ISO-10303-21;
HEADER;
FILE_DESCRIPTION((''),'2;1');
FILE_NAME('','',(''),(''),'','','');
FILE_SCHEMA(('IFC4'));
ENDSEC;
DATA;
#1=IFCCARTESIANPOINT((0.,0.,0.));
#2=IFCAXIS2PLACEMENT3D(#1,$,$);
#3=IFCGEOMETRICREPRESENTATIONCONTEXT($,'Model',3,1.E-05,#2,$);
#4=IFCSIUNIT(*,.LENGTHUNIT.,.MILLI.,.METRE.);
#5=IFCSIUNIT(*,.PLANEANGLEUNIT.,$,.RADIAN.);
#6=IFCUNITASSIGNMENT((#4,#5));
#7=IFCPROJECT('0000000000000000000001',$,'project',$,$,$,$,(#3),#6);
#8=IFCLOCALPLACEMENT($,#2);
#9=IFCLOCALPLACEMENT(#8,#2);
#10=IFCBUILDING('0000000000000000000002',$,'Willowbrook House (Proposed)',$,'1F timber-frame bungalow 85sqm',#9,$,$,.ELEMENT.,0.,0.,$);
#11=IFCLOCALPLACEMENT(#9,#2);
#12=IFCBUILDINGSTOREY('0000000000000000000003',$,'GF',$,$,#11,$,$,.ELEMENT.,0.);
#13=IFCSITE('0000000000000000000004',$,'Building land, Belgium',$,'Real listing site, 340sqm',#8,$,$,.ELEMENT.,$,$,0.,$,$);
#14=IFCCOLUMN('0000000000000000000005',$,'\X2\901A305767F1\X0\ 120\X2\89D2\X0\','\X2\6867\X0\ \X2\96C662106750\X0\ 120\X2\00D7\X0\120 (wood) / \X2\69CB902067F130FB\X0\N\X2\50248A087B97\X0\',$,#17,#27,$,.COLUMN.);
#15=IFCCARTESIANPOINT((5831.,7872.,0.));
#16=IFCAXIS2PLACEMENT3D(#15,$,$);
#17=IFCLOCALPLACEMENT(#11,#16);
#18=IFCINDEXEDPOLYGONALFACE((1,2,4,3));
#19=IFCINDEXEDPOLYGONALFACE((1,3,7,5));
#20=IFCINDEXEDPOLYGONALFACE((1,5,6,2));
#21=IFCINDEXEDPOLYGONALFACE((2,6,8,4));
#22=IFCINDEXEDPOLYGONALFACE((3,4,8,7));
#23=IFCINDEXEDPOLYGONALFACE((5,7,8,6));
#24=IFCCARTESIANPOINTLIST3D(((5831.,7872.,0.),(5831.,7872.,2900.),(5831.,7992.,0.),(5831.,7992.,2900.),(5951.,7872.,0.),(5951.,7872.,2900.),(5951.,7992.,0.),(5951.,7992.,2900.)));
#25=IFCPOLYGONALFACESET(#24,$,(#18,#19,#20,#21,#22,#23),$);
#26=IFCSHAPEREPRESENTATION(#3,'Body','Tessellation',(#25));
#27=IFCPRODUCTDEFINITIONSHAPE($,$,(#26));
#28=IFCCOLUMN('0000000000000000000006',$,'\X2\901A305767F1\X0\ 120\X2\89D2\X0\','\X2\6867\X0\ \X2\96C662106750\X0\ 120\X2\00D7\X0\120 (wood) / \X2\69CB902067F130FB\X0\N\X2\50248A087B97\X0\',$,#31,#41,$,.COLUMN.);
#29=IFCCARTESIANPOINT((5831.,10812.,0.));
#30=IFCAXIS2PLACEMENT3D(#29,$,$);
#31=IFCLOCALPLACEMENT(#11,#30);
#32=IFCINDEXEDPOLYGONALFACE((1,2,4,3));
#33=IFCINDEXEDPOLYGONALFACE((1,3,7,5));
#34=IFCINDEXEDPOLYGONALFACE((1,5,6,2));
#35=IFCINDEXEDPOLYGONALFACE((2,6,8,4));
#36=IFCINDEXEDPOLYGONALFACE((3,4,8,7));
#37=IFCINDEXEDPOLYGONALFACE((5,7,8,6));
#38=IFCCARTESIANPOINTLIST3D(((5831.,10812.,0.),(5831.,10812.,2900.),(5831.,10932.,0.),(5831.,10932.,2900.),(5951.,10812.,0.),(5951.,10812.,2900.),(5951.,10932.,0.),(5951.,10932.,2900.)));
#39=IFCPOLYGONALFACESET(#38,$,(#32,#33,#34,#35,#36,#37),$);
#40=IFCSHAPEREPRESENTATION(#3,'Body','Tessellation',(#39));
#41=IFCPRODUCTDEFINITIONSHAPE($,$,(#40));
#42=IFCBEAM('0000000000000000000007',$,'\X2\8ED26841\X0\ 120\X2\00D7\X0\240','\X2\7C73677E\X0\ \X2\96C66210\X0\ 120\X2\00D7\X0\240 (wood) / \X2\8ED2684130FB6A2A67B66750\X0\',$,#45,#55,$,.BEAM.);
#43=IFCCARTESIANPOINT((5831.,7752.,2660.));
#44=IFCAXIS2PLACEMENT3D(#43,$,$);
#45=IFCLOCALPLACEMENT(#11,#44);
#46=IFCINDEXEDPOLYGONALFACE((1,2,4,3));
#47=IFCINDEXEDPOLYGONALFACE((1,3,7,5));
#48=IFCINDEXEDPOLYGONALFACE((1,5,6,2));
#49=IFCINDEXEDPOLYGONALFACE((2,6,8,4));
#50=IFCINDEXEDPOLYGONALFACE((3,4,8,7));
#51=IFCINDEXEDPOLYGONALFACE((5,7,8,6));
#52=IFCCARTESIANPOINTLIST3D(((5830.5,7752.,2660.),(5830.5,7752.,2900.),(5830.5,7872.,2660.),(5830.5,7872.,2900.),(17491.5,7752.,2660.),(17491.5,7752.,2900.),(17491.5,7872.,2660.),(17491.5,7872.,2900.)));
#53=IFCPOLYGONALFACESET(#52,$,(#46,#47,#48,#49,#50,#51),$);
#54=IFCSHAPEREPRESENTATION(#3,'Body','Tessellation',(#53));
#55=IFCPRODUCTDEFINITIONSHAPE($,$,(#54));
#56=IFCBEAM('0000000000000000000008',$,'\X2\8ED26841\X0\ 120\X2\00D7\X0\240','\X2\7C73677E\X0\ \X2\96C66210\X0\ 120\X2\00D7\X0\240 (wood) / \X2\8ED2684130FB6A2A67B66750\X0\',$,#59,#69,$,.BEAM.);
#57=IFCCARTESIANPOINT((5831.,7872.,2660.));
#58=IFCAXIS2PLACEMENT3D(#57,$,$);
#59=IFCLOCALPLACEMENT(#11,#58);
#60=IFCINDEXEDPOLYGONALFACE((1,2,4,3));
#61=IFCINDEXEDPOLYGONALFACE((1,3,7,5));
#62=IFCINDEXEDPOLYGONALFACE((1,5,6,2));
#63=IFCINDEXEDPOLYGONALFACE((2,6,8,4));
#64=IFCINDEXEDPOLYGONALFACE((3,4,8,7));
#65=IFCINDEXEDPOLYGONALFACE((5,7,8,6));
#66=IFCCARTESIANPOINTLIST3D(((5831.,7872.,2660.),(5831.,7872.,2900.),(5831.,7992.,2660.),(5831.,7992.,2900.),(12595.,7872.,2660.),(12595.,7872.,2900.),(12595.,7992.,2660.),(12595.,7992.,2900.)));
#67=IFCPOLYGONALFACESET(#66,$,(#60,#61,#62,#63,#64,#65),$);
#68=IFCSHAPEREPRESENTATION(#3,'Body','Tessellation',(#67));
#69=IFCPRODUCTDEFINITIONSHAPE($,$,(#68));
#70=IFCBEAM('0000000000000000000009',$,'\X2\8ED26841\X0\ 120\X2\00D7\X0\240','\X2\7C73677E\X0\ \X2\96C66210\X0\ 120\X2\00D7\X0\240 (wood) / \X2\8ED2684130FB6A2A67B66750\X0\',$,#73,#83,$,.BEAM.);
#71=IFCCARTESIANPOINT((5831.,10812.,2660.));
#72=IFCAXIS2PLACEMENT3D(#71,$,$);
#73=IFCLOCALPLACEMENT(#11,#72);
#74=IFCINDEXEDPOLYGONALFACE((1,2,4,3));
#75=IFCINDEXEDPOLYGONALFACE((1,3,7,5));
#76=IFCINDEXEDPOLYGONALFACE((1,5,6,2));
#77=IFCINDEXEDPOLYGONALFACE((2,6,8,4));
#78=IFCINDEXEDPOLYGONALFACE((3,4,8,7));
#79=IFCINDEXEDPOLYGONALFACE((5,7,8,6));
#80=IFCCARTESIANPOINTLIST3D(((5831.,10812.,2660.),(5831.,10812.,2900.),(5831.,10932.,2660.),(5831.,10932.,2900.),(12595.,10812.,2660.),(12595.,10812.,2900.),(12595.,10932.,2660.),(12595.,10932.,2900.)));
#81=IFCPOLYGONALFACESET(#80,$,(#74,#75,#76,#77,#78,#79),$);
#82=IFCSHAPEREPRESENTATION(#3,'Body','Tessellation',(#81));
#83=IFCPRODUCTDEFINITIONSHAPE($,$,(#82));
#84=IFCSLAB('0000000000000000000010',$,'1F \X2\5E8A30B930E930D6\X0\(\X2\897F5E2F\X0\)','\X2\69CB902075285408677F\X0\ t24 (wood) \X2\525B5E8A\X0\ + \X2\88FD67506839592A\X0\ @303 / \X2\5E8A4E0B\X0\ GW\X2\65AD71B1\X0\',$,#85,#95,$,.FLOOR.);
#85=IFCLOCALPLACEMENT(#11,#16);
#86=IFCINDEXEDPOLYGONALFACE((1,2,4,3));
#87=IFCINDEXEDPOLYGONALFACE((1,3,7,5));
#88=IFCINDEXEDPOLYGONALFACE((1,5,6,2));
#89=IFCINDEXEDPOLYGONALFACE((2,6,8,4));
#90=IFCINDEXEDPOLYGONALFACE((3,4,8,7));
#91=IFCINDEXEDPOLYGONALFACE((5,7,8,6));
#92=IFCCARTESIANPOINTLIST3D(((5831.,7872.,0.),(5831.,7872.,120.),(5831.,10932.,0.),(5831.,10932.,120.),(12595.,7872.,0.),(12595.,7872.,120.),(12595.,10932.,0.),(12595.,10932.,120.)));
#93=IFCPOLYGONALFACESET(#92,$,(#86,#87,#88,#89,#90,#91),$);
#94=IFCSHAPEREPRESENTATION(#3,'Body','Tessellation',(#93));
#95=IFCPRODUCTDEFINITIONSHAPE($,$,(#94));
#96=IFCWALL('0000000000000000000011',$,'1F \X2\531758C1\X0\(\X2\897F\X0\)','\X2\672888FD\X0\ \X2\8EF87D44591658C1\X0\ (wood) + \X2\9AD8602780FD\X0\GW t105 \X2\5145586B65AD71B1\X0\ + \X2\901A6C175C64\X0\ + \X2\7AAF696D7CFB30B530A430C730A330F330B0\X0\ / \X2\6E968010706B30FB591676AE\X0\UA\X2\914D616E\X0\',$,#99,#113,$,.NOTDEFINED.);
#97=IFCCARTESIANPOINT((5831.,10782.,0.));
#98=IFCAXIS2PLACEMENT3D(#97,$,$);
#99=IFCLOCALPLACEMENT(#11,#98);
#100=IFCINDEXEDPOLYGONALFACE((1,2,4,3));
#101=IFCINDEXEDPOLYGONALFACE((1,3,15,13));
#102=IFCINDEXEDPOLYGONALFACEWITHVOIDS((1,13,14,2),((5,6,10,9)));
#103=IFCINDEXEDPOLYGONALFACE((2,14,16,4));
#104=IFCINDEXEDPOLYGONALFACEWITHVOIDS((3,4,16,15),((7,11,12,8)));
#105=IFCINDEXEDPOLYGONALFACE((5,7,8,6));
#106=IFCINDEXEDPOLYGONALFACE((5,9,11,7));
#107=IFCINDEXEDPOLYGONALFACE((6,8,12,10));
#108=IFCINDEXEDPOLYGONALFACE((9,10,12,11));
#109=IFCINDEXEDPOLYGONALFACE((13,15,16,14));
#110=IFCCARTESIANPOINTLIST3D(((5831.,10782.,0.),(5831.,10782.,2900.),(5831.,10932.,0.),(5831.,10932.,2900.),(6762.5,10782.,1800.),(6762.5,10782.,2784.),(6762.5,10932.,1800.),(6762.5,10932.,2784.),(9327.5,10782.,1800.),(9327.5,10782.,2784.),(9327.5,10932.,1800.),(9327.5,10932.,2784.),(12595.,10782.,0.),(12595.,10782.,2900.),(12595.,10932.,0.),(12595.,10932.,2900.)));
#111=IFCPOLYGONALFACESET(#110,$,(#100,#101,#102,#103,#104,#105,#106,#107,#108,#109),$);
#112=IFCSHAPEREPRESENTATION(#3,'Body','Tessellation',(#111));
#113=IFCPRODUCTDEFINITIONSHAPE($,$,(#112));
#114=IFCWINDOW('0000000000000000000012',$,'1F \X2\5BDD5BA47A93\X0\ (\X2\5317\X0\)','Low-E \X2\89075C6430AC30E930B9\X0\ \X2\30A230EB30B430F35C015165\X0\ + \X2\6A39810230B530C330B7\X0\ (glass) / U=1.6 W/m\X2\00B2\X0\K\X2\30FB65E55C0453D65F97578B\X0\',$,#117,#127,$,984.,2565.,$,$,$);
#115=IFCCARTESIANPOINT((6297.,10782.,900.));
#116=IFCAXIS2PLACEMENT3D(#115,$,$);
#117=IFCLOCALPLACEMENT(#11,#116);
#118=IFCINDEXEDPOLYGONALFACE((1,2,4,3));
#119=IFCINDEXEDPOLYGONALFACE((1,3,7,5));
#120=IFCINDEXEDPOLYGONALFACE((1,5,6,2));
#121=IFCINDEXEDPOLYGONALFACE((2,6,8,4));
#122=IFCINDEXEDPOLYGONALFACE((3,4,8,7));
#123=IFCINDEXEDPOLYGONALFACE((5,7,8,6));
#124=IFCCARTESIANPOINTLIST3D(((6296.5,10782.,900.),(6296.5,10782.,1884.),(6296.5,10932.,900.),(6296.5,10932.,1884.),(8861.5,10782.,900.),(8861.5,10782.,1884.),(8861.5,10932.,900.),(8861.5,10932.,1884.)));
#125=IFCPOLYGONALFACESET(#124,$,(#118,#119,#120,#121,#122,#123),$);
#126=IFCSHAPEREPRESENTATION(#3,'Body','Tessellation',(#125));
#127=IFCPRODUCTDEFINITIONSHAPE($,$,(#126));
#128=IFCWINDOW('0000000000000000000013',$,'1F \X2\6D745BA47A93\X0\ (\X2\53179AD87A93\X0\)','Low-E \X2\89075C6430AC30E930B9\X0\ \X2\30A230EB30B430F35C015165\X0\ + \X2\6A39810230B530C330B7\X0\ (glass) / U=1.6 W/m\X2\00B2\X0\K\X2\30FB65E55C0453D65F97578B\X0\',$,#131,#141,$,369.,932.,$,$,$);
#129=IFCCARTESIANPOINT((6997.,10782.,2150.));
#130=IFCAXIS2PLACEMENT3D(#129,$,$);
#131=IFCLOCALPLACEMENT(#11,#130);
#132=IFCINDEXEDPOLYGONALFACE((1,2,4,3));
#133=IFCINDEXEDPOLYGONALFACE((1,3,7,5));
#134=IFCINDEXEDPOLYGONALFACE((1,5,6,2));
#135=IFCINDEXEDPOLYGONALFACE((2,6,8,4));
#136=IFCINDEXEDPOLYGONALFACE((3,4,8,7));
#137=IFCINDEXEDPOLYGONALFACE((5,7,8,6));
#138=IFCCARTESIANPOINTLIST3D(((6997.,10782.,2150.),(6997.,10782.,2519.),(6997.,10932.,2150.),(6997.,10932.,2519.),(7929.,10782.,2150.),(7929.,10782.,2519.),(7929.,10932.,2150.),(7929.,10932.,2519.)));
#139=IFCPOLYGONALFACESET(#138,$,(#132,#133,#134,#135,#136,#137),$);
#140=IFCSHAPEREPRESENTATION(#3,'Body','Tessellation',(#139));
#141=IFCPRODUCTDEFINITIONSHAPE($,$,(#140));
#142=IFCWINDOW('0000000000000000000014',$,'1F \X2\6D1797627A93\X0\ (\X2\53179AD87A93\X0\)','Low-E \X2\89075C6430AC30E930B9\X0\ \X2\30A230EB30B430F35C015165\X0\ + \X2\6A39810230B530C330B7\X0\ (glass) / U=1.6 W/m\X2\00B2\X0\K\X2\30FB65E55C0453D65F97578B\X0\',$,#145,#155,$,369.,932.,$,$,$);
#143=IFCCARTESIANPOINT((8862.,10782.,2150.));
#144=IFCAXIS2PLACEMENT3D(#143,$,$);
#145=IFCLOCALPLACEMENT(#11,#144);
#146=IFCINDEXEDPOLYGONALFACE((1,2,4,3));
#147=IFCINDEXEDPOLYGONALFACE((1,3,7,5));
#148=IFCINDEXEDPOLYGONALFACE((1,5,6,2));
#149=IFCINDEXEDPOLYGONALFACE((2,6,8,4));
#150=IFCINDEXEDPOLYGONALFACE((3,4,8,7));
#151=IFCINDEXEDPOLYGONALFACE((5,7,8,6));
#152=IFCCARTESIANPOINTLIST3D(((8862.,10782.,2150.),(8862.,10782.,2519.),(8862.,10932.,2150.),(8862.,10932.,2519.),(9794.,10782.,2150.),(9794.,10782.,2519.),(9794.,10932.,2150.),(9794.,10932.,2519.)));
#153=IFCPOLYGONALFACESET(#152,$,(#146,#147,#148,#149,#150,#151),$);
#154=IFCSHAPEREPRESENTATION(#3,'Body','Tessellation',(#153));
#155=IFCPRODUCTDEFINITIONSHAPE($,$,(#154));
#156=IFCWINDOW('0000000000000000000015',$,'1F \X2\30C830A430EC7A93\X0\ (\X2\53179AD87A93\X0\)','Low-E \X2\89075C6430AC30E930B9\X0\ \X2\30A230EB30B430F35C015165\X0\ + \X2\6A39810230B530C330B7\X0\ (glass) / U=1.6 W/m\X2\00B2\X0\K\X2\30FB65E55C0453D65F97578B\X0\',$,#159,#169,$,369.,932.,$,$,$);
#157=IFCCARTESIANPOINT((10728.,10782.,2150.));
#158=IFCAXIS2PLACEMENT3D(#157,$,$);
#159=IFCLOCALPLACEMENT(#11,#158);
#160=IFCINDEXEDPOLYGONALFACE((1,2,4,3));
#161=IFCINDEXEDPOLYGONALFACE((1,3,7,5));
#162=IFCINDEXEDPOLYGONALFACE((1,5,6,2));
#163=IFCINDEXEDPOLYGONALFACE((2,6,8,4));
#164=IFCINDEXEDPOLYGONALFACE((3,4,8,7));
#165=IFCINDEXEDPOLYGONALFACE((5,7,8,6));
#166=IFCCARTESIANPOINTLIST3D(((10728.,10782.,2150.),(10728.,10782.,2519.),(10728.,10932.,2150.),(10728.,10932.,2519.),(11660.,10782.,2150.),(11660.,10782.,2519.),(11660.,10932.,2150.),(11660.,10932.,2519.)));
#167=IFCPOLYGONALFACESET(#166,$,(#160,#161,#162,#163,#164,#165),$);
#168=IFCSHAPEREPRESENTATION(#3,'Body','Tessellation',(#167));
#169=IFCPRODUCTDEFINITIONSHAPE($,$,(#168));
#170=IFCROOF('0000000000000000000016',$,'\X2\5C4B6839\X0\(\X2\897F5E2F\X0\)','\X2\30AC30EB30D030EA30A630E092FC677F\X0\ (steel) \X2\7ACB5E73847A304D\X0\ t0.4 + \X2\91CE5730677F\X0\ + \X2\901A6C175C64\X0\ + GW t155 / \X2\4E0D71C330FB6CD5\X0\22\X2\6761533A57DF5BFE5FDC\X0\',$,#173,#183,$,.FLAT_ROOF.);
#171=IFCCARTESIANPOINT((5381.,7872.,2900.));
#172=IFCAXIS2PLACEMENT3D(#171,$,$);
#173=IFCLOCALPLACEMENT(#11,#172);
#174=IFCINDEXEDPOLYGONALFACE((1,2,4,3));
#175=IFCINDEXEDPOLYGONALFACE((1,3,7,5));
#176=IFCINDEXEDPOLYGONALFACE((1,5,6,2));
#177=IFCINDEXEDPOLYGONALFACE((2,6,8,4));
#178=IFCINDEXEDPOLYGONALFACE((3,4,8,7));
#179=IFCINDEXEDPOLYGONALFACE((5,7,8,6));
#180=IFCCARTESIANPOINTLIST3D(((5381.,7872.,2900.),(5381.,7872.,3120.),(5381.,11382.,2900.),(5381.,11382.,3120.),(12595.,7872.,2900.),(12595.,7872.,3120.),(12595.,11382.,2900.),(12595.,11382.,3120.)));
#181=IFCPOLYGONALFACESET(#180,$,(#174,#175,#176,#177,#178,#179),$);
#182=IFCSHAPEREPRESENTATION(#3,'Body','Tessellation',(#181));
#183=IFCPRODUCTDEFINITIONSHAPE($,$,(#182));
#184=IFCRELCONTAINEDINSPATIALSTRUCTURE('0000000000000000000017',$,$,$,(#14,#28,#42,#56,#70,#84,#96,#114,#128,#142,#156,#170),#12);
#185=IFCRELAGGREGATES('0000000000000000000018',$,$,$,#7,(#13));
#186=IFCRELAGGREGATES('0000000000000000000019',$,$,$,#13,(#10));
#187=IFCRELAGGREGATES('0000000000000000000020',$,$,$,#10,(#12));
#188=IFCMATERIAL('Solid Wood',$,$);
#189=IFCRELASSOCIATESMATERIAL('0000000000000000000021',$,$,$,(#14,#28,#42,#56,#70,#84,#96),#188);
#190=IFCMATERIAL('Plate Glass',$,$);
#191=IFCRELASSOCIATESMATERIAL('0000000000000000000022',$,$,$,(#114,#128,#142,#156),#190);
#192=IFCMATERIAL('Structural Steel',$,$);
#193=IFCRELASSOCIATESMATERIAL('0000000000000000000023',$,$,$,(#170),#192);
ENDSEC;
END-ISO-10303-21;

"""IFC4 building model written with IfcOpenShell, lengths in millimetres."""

from ifc_helpers import new_model, si_unit, frame, frame_2d, origin, place, context, project, spatial, rectangle, extrude, material, element, fill, save


model = new_model("IFC4")

# Units and contexts
model_context = context("Model", 3, precision=1e-05, world=origin())
ifc_project = project(units=[si_unit("LENGTHUNIT", "METRE", prefix="MILLI"), si_unit("PLANEANGLEUNIT", "RADIAN")], contexts=[model_context])

# Site, building, storey
site_placement = place(None, origin())
site = spatial("IfcSite", under=ifc_project, at=site_placement, Name="Building land, Belgium", ObjectType="Real listing site, 340sqm", CompositionType="ELEMENT", RefElevation=0.0)
building_placement = place(site_placement, origin())
building = spatial("IfcBuilding", under=site, at=building_placement, Name="Willowbrook House (Proposed)", ObjectType="1F timber-frame bungalow 85sqm", CompositionType="ELEMENT", ElevationOfRefHeight=0.0, ElevationOfTerrain=0.0)
storey_placement = place(building_placement, origin())
storey = spatial("IfcBuildingStorey", under=building, at=storey_placement, Name="GF", CompositionType="ELEMENT", Elevation=0.0)

# Columns
ifc_material_1 = material(Name="Solid Wood")
column_1_placement = place(storey_placement, frame((5831.0, 7872.0, 0.0)))
element("IfcColumn", 1, at=column_1_placement, inside=storey, material=ifc_material_1, Name="通し柱 120角", Description="桧 集成材 120×120 (wood) / 構造柱・N値計算", PredefinedType="COLUMN", context=model_context, shape_type="SweptSolid", body=[
    extrude(rectangle(XDim=120.0, YDim=120.0, at=frame_2d((60.0, 60.0))), frame((5831.0, 7872.0, 0.0)), (0.0, 0.0, 1.0), 2900.0),
])
column_2_placement = place(storey_placement, frame((5831.0, 10812.0, 0.0)))
element("IfcColumn", 2, at=column_2_placement, inside=storey, material=ifc_material_1, Name="通し柱 120角", Description="桧 集成材 120×120 (wood) / 構造柱・N値計算", PredefinedType="COLUMN", context=model_context, shape_type="SweptSolid", body=[
    extrude(rectangle(XDim=120.0, YDim=120.0, at=frame_2d((60.0, 60.0))), frame((5831.0, 10812.0, 0.0)), (0.0, 0.0, 1.0), 2900.0),
])

# Beams
beam_1_placement = place(storey_placement, frame((5831.0, 7752.0, 2660.0)))
element("IfcBeam", 3, at=beam_1_placement, inside=storey, material=ifc_material_1, Name="軒桁 120×240", Description="米松 集成 120×240 (wood) / 軒桁・横架材", PredefinedType="BEAM", context=model_context, shape_type="SweptSolid", body=[
    extrude(rectangle(XDim=11661.0, YDim=120.0, at=frame_2d((5830.0, 60.0))), frame((5831.0, 7752.0, 2660.0)), (0.0, 0.0, 1.0), 240.0),
])
beam_2_placement = place(storey_placement, frame((5831.0, 7872.0, 2660.0)))
element("IfcBeam", 4, at=beam_2_placement, inside=storey, material=ifc_material_1, Name="軒桁 120×240", Description="米松 集成 120×240 (wood) / 軒桁・横架材", PredefinedType="BEAM", context=model_context, shape_type="SweptSolid", body=[
    extrude(rectangle(XDim=6764.0, YDim=120.0, at=frame_2d((3382.0, 60.0))), frame((5831.0, 7872.0, 2660.0)), (0.0, 0.0, 1.0), 240.0),
])
beam_3_placement = place(storey_placement, frame((5831.0, 10812.0, 2660.0)))
element("IfcBeam", 5, at=beam_3_placement, inside=storey, material=ifc_material_1, Name="軒桁 120×240", Description="米松 集成 120×240 (wood) / 軒桁・横架材", PredefinedType="BEAM", context=model_context, shape_type="SweptSolid", body=[
    extrude(rectangle(XDim=6764.0, YDim=120.0, at=frame_2d((3382.0, 60.0))), frame((5831.0, 10812.0, 2660.0)), (0.0, 0.0, 1.0), 240.0),
])

# Slab
slab_placement = place(storey_placement, frame((5831.0, 7872.0, 0.0)))
element("IfcSlab", 6, at=slab_placement, inside=storey, material=ifc_material_1, Name="1F 床スラブ(西帯)", Description="構造用合板 t24 (wood) 剛床 + 製材根太 @303 / 床下 GW断熱", PredefinedType="FLOOR", context=model_context, shape_type="SweptSolid", body=[
    extrude(rectangle(XDim=6764.0, YDim=3060.0, at=frame_2d((3382.0, 1530.0))), frame((5831.0, 7872.0, 0.0)), (0.0, 0.0, 1.0), 120.0),
])

# Wall, openings, windows
wall_1_placement = place(storey_placement, frame((5831.0, 10782.0, 0.0)))
wall_1 = element("IfcWall", 7, at=wall_1_placement, inside=storey, material=ifc_material_1, Name="1F 北壁(西)", Description="木製 軸組外壁 (wood) + 高性能GW t105 充填断熱 + 通気層 + 窯業系サイディング / 準耐火・外皮UA配慮", PredefinedType="NOTDEFINED", context=model_context, shape_type="SweptSolid", body=[
    extrude(rectangle(XDim=6764.0, YDim=150.0, at=frame_2d((3382.0, 75.0))), frame((5831.0, 10782.0, 0.0)), (0.0, 0.0, 1.0), 2900.0),
])
opening_1_placement = place(storey_placement, frame((6297.0, 10782.0, 900.0)))
opening_1 = element("IfcOpeningElement", 8, at=opening_1_placement, cuts=wall_1, PredefinedType="NOTDEFINED", context=model_context, shape_type="SweptSolid", body=[
    extrude(rectangle(XDim=2565.0, YDim=150.0, at=frame_2d((1282.0, 75.0))), frame((6297.0, 10782.0, 900.0)), (0.0, 0.0, 1.0), 984.0),
])
opening_2_placement = place(storey_placement, frame((6997.0, 10782.0, 2150.0)))
opening_2 = element("IfcOpeningElement", 9, at=opening_2_placement, cuts=wall_1, PredefinedType="NOTDEFINED", context=model_context, shape_type="SweptSolid", body=[
    extrude(rectangle(XDim=932.0, YDim=150.0, at=frame_2d((466.0, 75.0))), frame((6997.0, 10782.0, 2150.0)), (0.0, 0.0, 1.0), 369.0),
])
opening_3_placement = place(storey_placement, frame((8862.0, 10782.0, 2150.0)))
opening_3 = element("IfcOpeningElement", 10, at=opening_3_placement, cuts=wall_1, PredefinedType="NOTDEFINED", context=model_context, shape_type="SweptSolid", body=[
    extrude(rectangle(XDim=932.0, YDim=150.0, at=frame_2d((466.0, 75.0))), frame((8862.0, 10782.0, 2150.0)), (0.0, 0.0, 1.0), 369.0),
])
opening_4_placement = place(storey_placement, frame((10728.0, 10782.0, 2150.0)))
opening_4 = element("IfcOpeningElement", 11, at=opening_4_placement, cuts=wall_1, PredefinedType="NOTDEFINED", context=model_context, shape_type="SweptSolid", body=[
    extrude(rectangle(XDim=932.0, YDim=150.0, at=frame_2d((466.0, 75.0))), frame((10728.0, 10782.0, 2150.0)), (0.0, 0.0, 1.0), 369.0),
])
ifc_material_2 = material(Name="Plate Glass")
window_1_placement = place(storey_placement, frame((6297.0, 10782.0, 900.0)))
window_1 = element("IfcWindow", 12, at=window_1_placement, inside=storey, material=ifc_material_2, Name="1F 寝室窓 (北)", Description="Low-E 複層ガラス アルゴン封入 + 樹脂サッシ (glass) / U=1.6 W/m²K・日射取得型", OverallHeight=984.0, OverallWidth=2565.0, context=model_context, shape_type="SweptSolid", body=[
    extrude(rectangle(XDim=2565.0, YDim=150.0, at=frame_2d((1282.0, 75.0))), frame((6297.0, 10782.0, 900.0)), (0.0, 0.0, 1.0), 984.0),
])
fill(opening_1, window_1)
window_2_placement = place(storey_placement, frame((6997.0, 10782.0, 2150.0)))
window_2 = element("IfcWindow", 13, at=window_2_placement, inside=storey, material=ifc_material_2, Name="1F 浴室窓 (北高窓)", Description="Low-E 複層ガラス アルゴン封入 + 樹脂サッシ (glass) / U=1.6 W/m²K・日射取得型", OverallHeight=369.0, OverallWidth=932.0, context=model_context, shape_type="SweptSolid", body=[
    extrude(rectangle(XDim=932.0, YDim=150.0, at=frame_2d((466.0, 75.0))), frame((6997.0, 10782.0, 2150.0)), (0.0, 0.0, 1.0), 369.0),
])
fill(opening_2, window_2)
window_3_placement = place(storey_placement, frame((8862.0, 10782.0, 2150.0)))
window_3 = element("IfcWindow", 14, at=window_3_placement, inside=storey, material=ifc_material_2, Name="1F 洗面窓 (北高窓)", Description="Low-E 複層ガラス アルゴン封入 + 樹脂サッシ (glass) / U=1.6 W/m²K・日射取得型", OverallHeight=369.0, OverallWidth=932.0, context=model_context, shape_type="SweptSolid", body=[
    extrude(rectangle(XDim=932.0, YDim=150.0, at=frame_2d((466.0, 75.0))), frame((8862.0, 10782.0, 2150.0)), (0.0, 0.0, 1.0), 369.0),
])
fill(opening_3, window_3)
window_4_placement = place(storey_placement, frame((10728.0, 10782.0, 2150.0)))
window_4 = element("IfcWindow", 15, at=window_4_placement, inside=storey, material=ifc_material_2, Name="1F トイレ窓 (北高窓)", Description="Low-E 複層ガラス アルゴン封入 + 樹脂サッシ (glass) / U=1.6 W/m²K・日射取得型", OverallHeight=369.0, OverallWidth=932.0, context=model_context, shape_type="SweptSolid", body=[
    extrude(rectangle(XDim=932.0, YDim=150.0, at=frame_2d((466.0, 75.0))), frame((10728.0, 10782.0, 2150.0)), (0.0, 0.0, 1.0), 369.0),
])
fill(opening_4, window_4)

# Roof
ifc_material_3 = material(Name="Structural Steel")
roof_placement = place(storey_placement, frame((5381.0, 7872.0, 2900.0)))
element("IfcRoof", 16, at=roof_placement, inside=storey, material=ifc_material_3, Name="屋根(西帯)", Description="ガルバリウム鋼板 (steel) 立平葺き t0.4 + 野地板 + 通気層 + GW t155 / 不燃・法22条区域対応", PredefinedType="FLAT_ROOF", context=model_context, shape_type="SweptSolid", body=[
    extrude(rectangle(XDim=7214.0, YDim=3510.0, at=frame_2d((3607.0, 1755.0))), frame((5381.0, 7872.0, 2900.0)), (0.0, 0.0, 1.0), 220.0),
])

save(model, "model.ifc")
